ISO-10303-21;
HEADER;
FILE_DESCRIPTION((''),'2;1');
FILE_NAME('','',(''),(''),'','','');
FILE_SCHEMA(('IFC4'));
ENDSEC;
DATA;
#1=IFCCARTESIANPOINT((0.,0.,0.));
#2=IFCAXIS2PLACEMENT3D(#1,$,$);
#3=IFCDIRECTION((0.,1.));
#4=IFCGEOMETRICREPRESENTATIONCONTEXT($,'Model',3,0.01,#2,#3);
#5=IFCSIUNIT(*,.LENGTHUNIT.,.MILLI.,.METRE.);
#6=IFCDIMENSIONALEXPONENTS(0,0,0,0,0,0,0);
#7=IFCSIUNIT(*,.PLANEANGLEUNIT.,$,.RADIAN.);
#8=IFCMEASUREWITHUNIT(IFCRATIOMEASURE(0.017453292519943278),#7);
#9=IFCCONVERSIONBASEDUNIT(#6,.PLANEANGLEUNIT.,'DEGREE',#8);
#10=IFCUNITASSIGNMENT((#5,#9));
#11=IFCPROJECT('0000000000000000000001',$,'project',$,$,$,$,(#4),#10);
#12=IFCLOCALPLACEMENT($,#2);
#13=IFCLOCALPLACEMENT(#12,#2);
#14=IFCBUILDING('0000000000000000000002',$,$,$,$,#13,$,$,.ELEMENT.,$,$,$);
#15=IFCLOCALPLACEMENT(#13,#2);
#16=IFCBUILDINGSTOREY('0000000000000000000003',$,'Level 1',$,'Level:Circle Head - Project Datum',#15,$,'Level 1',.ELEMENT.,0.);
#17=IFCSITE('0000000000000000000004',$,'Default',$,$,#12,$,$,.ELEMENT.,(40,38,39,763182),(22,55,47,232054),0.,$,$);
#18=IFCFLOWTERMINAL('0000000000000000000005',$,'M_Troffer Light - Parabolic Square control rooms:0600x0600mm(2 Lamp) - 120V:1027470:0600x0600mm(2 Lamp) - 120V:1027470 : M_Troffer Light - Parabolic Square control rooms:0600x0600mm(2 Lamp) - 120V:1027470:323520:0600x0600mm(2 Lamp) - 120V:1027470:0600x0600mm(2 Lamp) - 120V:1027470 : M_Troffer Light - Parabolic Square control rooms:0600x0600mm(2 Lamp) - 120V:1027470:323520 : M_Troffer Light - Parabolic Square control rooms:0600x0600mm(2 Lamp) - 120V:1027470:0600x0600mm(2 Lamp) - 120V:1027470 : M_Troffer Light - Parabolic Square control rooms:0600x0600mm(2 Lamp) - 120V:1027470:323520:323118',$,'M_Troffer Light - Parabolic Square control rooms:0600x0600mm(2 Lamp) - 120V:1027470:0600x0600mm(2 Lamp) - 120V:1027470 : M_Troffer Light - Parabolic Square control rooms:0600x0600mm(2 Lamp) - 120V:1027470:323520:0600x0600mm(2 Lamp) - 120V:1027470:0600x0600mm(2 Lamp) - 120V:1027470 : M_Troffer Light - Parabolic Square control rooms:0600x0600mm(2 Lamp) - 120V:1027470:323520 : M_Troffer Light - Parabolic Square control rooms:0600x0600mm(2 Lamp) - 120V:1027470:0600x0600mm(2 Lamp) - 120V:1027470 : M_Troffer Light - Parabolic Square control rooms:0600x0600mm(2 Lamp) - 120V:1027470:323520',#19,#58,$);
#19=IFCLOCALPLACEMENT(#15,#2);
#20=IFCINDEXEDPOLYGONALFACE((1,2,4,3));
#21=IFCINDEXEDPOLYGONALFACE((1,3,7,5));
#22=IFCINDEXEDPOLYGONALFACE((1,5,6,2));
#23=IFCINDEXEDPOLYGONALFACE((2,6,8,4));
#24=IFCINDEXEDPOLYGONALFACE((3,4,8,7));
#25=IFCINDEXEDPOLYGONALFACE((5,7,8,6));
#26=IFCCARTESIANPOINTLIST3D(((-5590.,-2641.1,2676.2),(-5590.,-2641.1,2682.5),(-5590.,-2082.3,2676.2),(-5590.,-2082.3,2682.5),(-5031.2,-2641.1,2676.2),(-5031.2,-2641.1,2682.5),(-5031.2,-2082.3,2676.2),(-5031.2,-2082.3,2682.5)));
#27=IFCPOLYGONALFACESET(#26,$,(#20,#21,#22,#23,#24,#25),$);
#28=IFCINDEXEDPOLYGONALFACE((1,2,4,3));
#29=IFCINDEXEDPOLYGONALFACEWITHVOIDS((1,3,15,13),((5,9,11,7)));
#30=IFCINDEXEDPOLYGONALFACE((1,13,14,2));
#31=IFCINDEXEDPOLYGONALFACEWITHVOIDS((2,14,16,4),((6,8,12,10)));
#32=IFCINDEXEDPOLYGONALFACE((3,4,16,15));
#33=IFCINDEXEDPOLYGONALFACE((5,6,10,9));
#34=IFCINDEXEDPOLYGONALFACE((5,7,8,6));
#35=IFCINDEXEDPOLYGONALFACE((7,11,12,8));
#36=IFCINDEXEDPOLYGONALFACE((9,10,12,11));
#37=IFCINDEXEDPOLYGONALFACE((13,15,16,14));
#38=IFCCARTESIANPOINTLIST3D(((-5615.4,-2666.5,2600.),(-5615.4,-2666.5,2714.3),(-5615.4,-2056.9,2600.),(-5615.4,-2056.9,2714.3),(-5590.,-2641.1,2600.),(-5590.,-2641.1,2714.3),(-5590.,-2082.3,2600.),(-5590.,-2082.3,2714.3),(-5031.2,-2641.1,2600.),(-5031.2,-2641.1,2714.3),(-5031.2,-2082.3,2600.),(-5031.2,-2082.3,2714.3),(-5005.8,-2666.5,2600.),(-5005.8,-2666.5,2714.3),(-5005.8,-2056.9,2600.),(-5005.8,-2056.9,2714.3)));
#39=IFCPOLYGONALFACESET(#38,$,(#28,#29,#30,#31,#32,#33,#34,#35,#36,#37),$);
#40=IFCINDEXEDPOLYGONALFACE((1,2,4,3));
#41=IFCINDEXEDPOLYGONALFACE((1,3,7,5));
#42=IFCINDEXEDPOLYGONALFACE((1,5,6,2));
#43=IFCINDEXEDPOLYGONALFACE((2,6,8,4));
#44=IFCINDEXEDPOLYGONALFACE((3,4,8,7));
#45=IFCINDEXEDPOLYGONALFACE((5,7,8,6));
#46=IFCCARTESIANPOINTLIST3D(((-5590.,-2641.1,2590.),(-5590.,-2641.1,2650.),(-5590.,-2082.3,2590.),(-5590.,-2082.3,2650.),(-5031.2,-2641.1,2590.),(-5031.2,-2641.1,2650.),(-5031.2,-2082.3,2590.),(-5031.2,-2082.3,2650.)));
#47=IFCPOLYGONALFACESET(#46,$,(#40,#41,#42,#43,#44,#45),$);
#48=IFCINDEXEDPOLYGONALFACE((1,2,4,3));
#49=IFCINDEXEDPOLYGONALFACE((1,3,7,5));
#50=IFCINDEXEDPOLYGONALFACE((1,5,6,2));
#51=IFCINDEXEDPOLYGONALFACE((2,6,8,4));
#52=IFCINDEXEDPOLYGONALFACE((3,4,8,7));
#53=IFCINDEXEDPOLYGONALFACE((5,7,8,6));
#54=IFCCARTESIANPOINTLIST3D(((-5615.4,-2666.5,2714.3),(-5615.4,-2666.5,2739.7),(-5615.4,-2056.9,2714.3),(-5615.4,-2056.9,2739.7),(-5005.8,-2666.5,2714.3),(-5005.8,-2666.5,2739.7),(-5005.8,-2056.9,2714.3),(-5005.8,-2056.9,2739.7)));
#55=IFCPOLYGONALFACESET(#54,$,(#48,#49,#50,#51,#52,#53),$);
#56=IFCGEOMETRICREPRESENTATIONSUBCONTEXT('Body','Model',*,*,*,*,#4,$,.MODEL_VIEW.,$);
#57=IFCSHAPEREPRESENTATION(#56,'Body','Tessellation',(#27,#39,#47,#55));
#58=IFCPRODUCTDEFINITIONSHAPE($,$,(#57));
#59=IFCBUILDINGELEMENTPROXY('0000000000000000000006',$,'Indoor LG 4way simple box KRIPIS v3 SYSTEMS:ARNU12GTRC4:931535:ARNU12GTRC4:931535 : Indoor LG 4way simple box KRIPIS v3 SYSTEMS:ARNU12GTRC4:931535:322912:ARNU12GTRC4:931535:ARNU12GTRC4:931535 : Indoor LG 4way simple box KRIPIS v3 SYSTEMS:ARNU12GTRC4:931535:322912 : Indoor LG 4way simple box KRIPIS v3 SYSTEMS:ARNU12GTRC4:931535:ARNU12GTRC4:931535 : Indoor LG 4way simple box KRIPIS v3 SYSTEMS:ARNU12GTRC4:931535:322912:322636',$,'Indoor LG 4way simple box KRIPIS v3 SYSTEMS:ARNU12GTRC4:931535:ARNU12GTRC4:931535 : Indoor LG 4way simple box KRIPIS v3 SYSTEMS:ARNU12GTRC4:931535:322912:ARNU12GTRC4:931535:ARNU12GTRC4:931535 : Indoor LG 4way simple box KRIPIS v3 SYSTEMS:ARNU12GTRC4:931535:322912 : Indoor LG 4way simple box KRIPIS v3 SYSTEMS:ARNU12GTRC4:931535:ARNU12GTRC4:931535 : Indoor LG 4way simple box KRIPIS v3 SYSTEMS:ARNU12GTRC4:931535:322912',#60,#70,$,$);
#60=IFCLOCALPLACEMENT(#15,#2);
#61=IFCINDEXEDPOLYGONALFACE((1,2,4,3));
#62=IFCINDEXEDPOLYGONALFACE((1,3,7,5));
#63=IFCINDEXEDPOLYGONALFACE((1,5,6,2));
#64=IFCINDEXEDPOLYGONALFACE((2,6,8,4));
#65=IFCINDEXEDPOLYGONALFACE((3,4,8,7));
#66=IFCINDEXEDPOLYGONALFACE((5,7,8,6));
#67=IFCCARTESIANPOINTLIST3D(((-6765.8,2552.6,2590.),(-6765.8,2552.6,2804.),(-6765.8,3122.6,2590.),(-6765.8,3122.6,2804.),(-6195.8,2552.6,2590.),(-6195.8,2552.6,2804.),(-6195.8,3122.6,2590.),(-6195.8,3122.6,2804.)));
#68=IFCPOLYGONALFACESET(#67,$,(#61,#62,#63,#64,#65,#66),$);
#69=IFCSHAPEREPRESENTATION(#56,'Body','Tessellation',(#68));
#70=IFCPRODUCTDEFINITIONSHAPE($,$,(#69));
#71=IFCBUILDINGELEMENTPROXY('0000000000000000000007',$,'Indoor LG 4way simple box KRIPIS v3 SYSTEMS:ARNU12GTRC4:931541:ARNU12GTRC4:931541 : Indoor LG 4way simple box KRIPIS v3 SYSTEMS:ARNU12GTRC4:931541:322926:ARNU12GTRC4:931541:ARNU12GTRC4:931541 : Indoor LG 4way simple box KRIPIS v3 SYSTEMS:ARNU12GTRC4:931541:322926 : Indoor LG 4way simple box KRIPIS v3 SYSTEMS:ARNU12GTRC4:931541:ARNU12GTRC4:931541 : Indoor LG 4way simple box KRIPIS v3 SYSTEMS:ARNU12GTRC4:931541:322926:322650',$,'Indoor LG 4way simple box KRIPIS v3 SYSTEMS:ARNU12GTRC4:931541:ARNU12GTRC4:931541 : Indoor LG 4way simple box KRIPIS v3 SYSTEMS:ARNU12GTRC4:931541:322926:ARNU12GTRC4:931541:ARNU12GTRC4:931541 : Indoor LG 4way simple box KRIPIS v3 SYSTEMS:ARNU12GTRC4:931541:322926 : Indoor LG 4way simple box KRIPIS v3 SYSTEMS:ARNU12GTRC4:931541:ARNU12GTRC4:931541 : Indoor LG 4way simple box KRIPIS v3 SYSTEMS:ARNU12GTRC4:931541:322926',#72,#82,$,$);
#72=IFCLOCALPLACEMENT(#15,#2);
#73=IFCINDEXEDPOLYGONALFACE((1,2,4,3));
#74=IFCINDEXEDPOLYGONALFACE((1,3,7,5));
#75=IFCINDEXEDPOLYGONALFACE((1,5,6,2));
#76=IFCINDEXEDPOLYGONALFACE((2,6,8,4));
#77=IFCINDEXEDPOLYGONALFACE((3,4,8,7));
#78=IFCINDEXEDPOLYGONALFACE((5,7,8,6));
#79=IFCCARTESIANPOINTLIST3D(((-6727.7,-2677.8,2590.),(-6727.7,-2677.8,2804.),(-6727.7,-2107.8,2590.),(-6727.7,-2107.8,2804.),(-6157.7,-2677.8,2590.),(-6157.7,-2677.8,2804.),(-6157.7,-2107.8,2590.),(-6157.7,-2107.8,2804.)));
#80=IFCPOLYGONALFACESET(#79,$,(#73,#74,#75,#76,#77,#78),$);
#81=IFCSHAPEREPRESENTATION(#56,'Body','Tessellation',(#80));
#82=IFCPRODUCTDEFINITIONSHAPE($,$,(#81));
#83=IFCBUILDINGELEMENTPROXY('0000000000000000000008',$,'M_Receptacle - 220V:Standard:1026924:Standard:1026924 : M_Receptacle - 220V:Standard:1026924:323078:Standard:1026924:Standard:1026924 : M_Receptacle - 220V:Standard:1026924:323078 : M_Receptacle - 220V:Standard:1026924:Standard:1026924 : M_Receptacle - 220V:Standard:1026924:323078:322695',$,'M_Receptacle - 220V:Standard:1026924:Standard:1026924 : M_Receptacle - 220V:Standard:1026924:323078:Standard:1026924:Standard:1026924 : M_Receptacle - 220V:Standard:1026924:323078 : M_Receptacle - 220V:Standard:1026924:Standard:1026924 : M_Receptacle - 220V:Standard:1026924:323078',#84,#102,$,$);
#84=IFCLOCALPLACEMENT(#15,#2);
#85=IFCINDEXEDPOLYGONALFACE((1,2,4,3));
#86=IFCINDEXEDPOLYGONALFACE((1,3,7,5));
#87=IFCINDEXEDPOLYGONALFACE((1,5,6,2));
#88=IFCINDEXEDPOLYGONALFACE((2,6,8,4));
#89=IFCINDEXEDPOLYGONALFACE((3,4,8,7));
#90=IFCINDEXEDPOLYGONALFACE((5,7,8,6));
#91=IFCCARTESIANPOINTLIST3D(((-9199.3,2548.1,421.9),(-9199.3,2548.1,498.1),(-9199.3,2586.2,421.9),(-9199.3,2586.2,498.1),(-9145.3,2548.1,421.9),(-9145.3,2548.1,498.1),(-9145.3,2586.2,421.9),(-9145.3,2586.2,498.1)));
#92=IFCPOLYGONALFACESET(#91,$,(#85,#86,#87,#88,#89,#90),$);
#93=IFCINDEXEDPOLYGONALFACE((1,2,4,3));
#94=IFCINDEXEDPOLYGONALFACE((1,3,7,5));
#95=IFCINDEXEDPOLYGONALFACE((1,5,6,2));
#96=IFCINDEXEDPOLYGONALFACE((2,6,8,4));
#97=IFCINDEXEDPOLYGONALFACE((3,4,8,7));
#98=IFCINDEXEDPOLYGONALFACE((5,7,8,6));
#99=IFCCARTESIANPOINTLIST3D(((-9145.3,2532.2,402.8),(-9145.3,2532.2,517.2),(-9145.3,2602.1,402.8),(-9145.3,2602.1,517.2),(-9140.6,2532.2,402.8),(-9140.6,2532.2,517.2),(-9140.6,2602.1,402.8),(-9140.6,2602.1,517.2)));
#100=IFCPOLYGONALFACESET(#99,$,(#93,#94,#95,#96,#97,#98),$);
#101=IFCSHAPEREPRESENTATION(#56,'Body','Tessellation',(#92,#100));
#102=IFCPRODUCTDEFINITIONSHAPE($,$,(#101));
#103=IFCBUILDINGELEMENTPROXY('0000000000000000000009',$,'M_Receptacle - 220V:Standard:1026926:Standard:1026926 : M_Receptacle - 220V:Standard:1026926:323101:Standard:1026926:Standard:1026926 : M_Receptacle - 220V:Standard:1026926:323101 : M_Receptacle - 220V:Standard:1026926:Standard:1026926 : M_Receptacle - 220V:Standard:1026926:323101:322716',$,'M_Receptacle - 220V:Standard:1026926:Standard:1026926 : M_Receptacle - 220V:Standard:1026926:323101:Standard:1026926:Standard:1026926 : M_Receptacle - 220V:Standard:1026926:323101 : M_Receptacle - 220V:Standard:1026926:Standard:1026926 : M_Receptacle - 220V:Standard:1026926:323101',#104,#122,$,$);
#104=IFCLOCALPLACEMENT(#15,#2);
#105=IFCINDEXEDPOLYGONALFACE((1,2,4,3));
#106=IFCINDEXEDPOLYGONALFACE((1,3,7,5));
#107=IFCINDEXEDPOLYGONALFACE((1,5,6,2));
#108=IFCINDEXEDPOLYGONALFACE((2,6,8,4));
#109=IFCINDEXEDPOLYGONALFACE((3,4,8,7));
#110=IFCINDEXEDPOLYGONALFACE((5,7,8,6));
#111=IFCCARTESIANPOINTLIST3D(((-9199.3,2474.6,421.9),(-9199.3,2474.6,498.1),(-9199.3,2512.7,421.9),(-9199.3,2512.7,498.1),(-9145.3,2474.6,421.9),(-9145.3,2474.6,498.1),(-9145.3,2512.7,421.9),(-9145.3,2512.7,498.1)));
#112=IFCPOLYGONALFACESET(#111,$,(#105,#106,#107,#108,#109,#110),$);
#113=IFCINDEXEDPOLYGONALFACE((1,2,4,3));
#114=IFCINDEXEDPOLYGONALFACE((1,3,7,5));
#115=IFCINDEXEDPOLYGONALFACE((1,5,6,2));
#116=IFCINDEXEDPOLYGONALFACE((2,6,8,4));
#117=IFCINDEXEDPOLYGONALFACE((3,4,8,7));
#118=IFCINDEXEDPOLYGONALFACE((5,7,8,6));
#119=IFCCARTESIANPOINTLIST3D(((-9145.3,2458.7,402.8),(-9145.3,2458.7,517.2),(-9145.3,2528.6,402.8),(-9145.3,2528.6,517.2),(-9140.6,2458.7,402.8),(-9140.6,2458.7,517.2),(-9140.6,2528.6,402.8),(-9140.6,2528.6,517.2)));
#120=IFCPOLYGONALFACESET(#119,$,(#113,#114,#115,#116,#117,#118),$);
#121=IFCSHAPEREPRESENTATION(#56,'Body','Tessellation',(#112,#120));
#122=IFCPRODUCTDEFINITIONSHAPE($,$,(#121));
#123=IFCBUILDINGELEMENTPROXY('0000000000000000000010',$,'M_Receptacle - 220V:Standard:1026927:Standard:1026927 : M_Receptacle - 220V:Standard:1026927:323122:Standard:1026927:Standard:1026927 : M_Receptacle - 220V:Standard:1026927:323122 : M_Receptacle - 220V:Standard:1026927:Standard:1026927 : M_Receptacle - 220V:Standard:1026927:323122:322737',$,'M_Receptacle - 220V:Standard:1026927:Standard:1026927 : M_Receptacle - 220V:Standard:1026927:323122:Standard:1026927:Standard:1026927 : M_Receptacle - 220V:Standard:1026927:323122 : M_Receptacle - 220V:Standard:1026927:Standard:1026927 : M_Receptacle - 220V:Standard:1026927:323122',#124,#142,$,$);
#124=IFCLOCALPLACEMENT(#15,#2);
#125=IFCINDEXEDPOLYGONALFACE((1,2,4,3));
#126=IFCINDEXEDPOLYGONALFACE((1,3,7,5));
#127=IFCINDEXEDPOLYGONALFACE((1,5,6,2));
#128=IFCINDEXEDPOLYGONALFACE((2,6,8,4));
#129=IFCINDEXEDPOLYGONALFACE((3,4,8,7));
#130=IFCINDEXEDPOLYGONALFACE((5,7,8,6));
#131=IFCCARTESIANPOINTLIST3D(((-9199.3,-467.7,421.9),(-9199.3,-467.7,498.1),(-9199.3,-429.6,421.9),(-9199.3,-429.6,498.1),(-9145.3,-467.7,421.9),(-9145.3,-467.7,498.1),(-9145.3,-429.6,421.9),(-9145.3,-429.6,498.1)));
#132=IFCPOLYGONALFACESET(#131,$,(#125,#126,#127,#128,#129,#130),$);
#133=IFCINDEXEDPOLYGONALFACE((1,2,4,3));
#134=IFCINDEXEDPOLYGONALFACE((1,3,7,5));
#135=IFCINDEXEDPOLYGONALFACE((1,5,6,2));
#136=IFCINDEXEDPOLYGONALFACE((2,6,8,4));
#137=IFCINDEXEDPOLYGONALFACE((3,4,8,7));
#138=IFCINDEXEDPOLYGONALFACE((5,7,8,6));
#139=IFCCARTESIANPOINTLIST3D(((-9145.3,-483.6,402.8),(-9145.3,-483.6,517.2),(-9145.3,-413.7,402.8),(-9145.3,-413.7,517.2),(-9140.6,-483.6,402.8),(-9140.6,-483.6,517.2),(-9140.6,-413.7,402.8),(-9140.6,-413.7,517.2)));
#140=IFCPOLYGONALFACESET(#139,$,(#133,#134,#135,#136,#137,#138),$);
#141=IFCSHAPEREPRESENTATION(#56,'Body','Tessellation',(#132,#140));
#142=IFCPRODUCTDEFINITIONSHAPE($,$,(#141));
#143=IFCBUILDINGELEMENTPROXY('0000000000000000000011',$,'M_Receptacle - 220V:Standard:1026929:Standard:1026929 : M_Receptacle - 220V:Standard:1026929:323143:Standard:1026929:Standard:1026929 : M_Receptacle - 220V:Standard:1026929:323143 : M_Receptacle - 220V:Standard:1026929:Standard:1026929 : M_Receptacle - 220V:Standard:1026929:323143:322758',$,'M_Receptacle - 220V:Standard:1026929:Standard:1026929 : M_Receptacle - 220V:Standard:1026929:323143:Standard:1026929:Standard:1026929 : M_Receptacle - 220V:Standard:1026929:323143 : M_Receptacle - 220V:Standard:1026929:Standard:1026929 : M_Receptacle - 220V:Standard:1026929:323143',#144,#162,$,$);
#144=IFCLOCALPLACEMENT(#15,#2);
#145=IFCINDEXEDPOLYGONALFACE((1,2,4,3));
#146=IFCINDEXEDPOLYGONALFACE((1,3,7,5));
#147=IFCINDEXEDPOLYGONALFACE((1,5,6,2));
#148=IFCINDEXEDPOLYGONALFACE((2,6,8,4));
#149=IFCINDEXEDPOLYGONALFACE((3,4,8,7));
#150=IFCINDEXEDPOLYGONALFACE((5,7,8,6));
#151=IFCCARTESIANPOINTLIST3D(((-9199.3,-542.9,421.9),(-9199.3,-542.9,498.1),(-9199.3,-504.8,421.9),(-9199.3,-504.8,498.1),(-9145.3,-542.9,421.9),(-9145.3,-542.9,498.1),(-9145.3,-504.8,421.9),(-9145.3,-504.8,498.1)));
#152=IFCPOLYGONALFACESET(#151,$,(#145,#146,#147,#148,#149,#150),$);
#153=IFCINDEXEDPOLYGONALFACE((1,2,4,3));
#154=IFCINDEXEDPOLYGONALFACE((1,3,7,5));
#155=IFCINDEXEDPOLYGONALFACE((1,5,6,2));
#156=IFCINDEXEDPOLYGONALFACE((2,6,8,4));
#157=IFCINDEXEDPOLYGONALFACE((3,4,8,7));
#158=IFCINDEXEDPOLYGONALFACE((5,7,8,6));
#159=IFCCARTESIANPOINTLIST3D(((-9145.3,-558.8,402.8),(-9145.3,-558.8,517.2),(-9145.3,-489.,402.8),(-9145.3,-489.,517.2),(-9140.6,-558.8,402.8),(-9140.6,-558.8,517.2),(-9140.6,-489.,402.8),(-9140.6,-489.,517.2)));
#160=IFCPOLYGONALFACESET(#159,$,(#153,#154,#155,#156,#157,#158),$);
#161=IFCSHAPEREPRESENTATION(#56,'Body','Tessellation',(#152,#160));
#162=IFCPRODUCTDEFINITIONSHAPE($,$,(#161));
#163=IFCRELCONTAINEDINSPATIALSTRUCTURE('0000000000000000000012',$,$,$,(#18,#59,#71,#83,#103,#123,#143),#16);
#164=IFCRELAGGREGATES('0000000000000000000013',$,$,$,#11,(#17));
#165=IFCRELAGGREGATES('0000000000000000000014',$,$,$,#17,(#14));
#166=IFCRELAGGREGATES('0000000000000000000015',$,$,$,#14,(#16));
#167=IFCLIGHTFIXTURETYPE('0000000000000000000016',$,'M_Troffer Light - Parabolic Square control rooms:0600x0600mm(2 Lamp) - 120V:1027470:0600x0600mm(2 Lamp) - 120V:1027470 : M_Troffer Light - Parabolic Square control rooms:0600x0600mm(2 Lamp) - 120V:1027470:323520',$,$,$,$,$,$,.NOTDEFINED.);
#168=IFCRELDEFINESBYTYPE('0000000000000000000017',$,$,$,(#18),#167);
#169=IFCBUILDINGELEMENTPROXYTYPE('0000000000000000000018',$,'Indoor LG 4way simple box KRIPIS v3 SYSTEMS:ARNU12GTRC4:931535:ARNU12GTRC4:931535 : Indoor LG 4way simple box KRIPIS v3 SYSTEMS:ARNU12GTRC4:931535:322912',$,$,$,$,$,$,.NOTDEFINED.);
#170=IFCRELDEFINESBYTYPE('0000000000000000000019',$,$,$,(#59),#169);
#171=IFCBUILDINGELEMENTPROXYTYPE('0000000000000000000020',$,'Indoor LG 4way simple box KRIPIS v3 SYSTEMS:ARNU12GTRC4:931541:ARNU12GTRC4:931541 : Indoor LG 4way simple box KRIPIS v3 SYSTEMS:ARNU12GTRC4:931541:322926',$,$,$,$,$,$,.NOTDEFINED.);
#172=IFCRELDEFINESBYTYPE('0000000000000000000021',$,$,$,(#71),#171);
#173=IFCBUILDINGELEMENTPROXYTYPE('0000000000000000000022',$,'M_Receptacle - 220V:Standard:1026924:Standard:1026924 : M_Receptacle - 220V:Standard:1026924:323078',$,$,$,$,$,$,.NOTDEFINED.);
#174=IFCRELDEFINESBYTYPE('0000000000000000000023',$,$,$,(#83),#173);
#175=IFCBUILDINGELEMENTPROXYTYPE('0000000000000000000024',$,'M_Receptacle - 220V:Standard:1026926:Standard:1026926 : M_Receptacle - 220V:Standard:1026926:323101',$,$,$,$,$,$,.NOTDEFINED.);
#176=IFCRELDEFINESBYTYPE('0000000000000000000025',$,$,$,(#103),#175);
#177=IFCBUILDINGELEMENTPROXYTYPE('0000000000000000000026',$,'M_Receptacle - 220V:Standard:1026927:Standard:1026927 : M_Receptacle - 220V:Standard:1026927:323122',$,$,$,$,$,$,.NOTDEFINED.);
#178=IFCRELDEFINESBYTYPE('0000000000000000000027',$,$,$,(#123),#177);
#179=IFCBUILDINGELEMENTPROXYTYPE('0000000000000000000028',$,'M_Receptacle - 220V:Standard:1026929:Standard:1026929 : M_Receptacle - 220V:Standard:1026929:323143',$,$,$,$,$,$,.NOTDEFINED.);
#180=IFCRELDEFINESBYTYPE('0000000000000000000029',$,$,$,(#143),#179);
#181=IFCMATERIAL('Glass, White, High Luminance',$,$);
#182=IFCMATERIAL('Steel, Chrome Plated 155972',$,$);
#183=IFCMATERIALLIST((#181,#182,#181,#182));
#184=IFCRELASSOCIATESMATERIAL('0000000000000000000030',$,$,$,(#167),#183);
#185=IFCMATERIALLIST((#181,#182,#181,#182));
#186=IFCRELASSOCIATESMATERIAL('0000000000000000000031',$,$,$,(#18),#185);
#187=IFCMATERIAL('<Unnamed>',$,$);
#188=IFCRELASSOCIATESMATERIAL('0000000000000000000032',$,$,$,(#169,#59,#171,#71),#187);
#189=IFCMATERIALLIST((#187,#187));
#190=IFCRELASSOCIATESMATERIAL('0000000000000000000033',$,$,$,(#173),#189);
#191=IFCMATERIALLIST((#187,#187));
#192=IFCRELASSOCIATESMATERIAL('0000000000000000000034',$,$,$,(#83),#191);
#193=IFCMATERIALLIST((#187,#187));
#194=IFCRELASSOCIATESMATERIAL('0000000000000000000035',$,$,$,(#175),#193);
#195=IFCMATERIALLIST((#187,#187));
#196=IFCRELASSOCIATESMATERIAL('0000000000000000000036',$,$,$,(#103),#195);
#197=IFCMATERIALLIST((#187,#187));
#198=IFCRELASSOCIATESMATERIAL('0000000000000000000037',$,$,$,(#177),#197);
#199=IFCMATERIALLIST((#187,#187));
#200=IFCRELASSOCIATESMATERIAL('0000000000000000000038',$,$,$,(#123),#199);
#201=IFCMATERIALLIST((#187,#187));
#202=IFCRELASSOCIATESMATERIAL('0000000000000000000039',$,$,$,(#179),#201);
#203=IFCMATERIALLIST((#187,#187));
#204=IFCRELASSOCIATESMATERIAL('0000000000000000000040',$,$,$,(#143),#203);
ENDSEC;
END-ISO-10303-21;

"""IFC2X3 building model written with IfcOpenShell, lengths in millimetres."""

from ifc_helpers import new_model, entity, si_unit, converted_unit, direction, frame, frame_2d, origin, origin_2d_with_axis, place, context, subcontext, project, spatial, polyline, rectangle, outline, extrude, source, transform, mapped, material, material_list, type_object, type_shapes, element, save


model = new_model("IFC2X3")

# Units and contexts
model_context = context("Model", 3, precision=0.01, world=origin(), true_north=direction((0.0, 1.0)))
body_context = subcontext(model_context, "Body", "Model", "MODEL_VIEW")
ifc_project = project(units=[si_unit("LENGTHUNIT", "METRE", prefix="MILLI"), converted_unit("PLANEANGLEUNIT", "DEGREE", entity("IfcRatioMeasure", 0.017453292519943278), si_unit("PLANEANGLEUNIT", "RADIAN"), dimensions=[0, 0, 0, 0, 0, 0, 0])], contexts=[model_context])

# Site, building, storey
site_placement = place(None, origin())
site = spatial("IfcSite", under=ifc_project, at=site_placement, Name="Default", CompositionType="ELEMENT", RefLatitude=(40, 38, 39, 763182), RefLongitude=(22, 55, 47, 232054), RefElevation=0.0)
building_placement = place(site_placement, origin())
building = spatial("IfcBuilding", under=site, at=building_placement, CompositionType="ELEMENT")
storey_placement = place(building_placement, origin())
storey = spatial("IfcBuildingStorey", under=building, at=storey_placement, Name="Level 1", ObjectType="Level:Circle Head - Project Datum", LongName="Level 1", CompositionType="ELEMENT", Elevation=0.0)

# Shared definitions
ifc_material_1 = material(Name="<Unnamed>")

# Flow terminal
ifc_material_2 = material(Name="Glass, White, High Luminance")
ifc_material_3 = material(Name="Steel, Chrome Plated 155972")
ifc_material_list_1 = material_list([ifc_material_2, ifc_material_3, ifc_material_2, ifc_material_3])
ifc_material_list_2 = material_list([ifc_material_2, ifc_material_3, ifc_material_2, ifc_material_3])
light_fixture_type_1 = type_object("IfcLightFixtureType", Name="M_Troffer Light - Parabolic Square control rooms:0600x0600mm(2 Lamp) - 120V:1027470:0600x0600mm(2 Lamp) - 120V:1027470 : M_Troffer Light - Parabolic Square control rooms:0600x0600mm(2 Lamp) - 120V:1027470:323520", PredefinedType="NOTDEFINED", material=ifc_material_list_2)
shared_shape_1 = source(origin(), body_context, "Body", "SweptSolid", [
    extrude(rectangle(XDim=558.8, YDim=558.8, at=frame_2d((0.0, 0.0), x_axis=(1.0, 0.0))), frame((-5310.6, -2361.7, 2676.2), z_axis=(0.0, 0.0, 1.0), x_axis=(0.0, 1.0, 0.0)), (0.0, 0.0, 1.0), 6.4),
    extrude(outline(polyline([(-304.8, -304.8), (304.8, -304.8), (304.8, 304.8), (-304.8, 304.8), (-304.8, -304.8)]), holes=[polyline([(279.4, 279.4), (279.4, -279.4), (-279.4, -279.4), (-279.4, 279.4), (279.4, 279.4)])]), frame((-5310.6, -2361.7, 2600.0), z_axis=(0.0, 0.0, 1.0), x_axis=(0.0, -1.0, 0.0)), (0.0, 0.0, 1.0), 114.3),
    extrude(rectangle(XDim=558.8, YDim=558.8, at=frame_2d((0.0, 0.0), x_axis=(1.0, 0.0))), frame((-5310.6, -2361.7, 2590.0), z_axis=(0.0, 0.0, 1.0), x_axis=(0.0, 1.0, 0.0)), (0.0, 0.0, 1.0), 60.0),
    extrude(rectangle(XDim=609.6, YDim=609.6, at=origin_2d_with_axis()), frame((-5310.6, -2361.7, 2714.3), z_axis=(0.0, 0.0, 1.0), x_axis=(0.0, 1.0, 0.0)), (0.0, 0.0, 1.0), 25.4),
])
type_shapes(light_fixture_type_1, [shared_shape_1])
flow_terminal_1_placement = place(storey_placement, origin())
element("IfcFlowTerminal", 1, at=flow_terminal_1_placement, inside=storey, type_object=light_fixture_type_1, material=ifc_material_list_1, Name="M_Troffer Light - Parabolic Square control rooms:0600x0600mm(2 Lamp) - 120V:1027470:0600x0600mm(2 Lamp) - 120V:1027470 : M_Troffer Light - Parabolic Square control rooms:0600x0600mm(2 Lamp) - 120V:1027470:323520:0600x0600mm(2 Lamp) - 120V:1027470:0600x0600mm(2 Lamp) - 120V:1027470 : M_Troffer Light - Parabolic Square control rooms:0600x0600mm(2 Lamp) - 120V:1027470:323520 : M_Troffer Light - Parabolic Square control rooms:0600x0600mm(2 Lamp) - 120V:1027470:0600x0600mm(2 Lamp) - 120V:1027470 : M_Troffer Light - Parabolic Square control rooms:0600x0600mm(2 Lamp) - 120V:1027470:323520:323118", ObjectType="M_Troffer Light - Parabolic Square control rooms:0600x0600mm(2 Lamp) - 120V:1027470:0600x0600mm(2 Lamp) - 120V:1027470 : M_Troffer Light - Parabolic Square control rooms:0600x0600mm(2 Lamp) - 120V:1027470:323520:0600x0600mm(2 Lamp) - 120V:1027470:0600x0600mm(2 Lamp) - 120V:1027470 : M_Troffer Light - Parabolic Square control rooms:0600x0600mm(2 Lamp) - 120V:1027470:323520 : M_Troffer Light - Parabolic Square control rooms:0600x0600mm(2 Lamp) - 120V:1027470:0600x0600mm(2 Lamp) - 120V:1027470 : M_Troffer Light - Parabolic Square control rooms:0600x0600mm(2 Lamp) - 120V:1027470:323520", context=body_context, shape_type="MappedRepresentation", body=[
    mapped(shared_shape_1, transform((0.0, 0.0, 0.0), scale=1.0)),
])

# Building element proxies
building_element_proxy_type_1 = type_object("IfcBuildingElementProxyType", Name="Indoor LG 4way simple box KRIPIS v3 SYSTEMS:ARNU12GTRC4:931535:ARNU12GTRC4:931535 : Indoor LG 4way simple box KRIPIS v3 SYSTEMS:ARNU12GTRC4:931535:322912", PredefinedType="NOTDEFINED", material=ifc_material_1)
shared_shape_2 = source(origin(), body_context, "Body", "SweptSolid", [
    extrude(rectangle(XDim=570.0, YDim=570.0, at=frame_2d((0.0, 0.0), x_axis=(1.0, 0.0))), frame((-6480.8, 2837.6, 2590.0), z_axis=(0.0, 0.0, 1.0), x_axis=(0.0, 1.0, 0.0)), (0.0, 0.0, 1.0), 214.0),
])
type_shapes(building_element_proxy_type_1, [shared_shape_2])
proxy_1_placement = place(storey_placement, origin())
element("IfcBuildingElementProxy", 2, at=proxy_1_placement, inside=storey, type_object=building_element_proxy_type_1, material=ifc_material_1, Name="Indoor LG 4way simple box KRIPIS v3 SYSTEMS:ARNU12GTRC4:931535:ARNU12GTRC4:931535 : Indoor LG 4way simple box KRIPIS v3 SYSTEMS:ARNU12GTRC4:931535:322912:ARNU12GTRC4:931535:ARNU12GTRC4:931535 : Indoor LG 4way simple box KRIPIS v3 SYSTEMS:ARNU12GTRC4:931535:322912 : Indoor LG 4way simple box KRIPIS v3 SYSTEMS:ARNU12GTRC4:931535:ARNU12GTRC4:931535 : Indoor LG 4way simple box KRIPIS v3 SYSTEMS:ARNU12GTRC4:931535:322912:322636", ObjectType="Indoor LG 4way simple box KRIPIS v3 SYSTEMS:ARNU12GTRC4:931535:ARNU12GTRC4:931535 : Indoor LG 4way simple box KRIPIS v3 SYSTEMS:ARNU12GTRC4:931535:322912:ARNU12GTRC4:931535:ARNU12GTRC4:931535 : Indoor LG 4way simple box KRIPIS v3 SYSTEMS:ARNU12GTRC4:931535:322912 : Indoor LG 4way simple box KRIPIS v3 SYSTEMS:ARNU12GTRC4:931535:ARNU12GTRC4:931535 : Indoor LG 4way simple box KRIPIS v3 SYSTEMS:ARNU12GTRC4:931535:322912", context=body_context, shape_type="MappedRepresentation", body=[
    mapped(shared_shape_2, transform((0.0, 0.0, 0.0), scale=1.0)),
])
building_element_proxy_type_2 = type_object("IfcBuildingElementProxyType", Name="Indoor LG 4way simple box KRIPIS v3 SYSTEMS:ARNU12GTRC4:931541:ARNU12GTRC4:931541 : Indoor LG 4way simple box KRIPIS v3 SYSTEMS:ARNU12GTRC4:931541:322926", PredefinedType="NOTDEFINED", material=ifc_material_1)
shared_shape_3 = source(origin(), body_context, "Body", "SweptSolid", [
    extrude(rectangle(XDim=570.0, YDim=570.0, at=frame_2d((0.0, 0.0), x_axis=(1.0, 0.0))), frame((-6442.7, -2392.8, 2590.0), z_axis=(0.0, 0.0, 1.0), x_axis=(0.0, 1.0, 0.0)), (0.0, 0.0, 1.0), 214.0),
])
type_shapes(building_element_proxy_type_2, [shared_shape_3])
proxy_2_placement = place(storey_placement, origin())
element("IfcBuildingElementProxy", 3, at=proxy_2_placement, inside=storey, type_object=building_element_proxy_type_2, material=ifc_material_1, Name="Indoor LG 4way simple box KRIPIS v3 SYSTEMS:ARNU12GTRC4:931541:ARNU12GTRC4:931541 : Indoor LG 4way simple box KRIPIS v3 SYSTEMS:ARNU12GTRC4:931541:322926:ARNU12GTRC4:931541:ARNU12GTRC4:931541 : Indoor LG 4way simple box KRIPIS v3 SYSTEMS:ARNU12GTRC4:931541:322926 : Indoor LG 4way simple box KRIPIS v3 SYSTEMS:ARNU12GTRC4:931541:ARNU12GTRC4:931541 : Indoor LG 4way simple box KRIPIS v3 SYSTEMS:ARNU12GTRC4:931541:322926:322650", ObjectType="Indoor LG 4way simple box KRIPIS v3 SYSTEMS:ARNU12GTRC4:931541:ARNU12GTRC4:931541 : Indoor LG 4way simple box KRIPIS v3 SYSTEMS:ARNU12GTRC4:931541:322926:ARNU12GTRC4:931541:ARNU12GTRC4:931541 : Indoor LG 4way simple box KRIPIS v3 SYSTEMS:ARNU12GTRC4:931541:322926 : Indoor LG 4way simple box KRIPIS v3 SYSTEMS:ARNU12GTRC4:931541:ARNU12GTRC4:931541 : Indoor LG 4way simple box KRIPIS v3 SYSTEMS:ARNU12GTRC4:931541:322926", context=body_context, shape_type="MappedRepresentation", body=[
    mapped(shared_shape_3, transform((0.0, 0.0, 0.0), scale=1.0)),
])
ifc_material_list_3 = material_list([ifc_material_1, ifc_material_1])
ifc_material_list_4 = material_list([ifc_material_1, ifc_material_1])
building_element_proxy_type_3 = type_object("IfcBuildingElementProxyType", Name="M_Receptacle - 220V:Standard:1026924:Standard:1026924 : M_Receptacle - 220V:Standard:1026924:323078", PredefinedType="NOTDEFINED", material=ifc_material_list_4)
shared_shape_4 = source(origin(), body_context, "Body", "SweptSolid", [
    extrude(rectangle(XDim=38.1, YDim=54.0, at=frame_2d((0.0, 0.0), x_axis=(1.0, 0.0))), frame((-9172.3, 2567.2, 421.9), z_axis=(0.0, 0.0, 1.0), x_axis=(0.0, -1.0, 0.0)), (0.0, 0.0, 1.0), 76.2),
    extrude(rectangle(XDim=69.8, YDim=4.8, at=frame_2d((0.0, 0.0), x_axis=(1.0, 0.0))), frame((-9143.0, 2567.2, 402.8), z_axis=(0.0, 0.0, 1.0), x_axis=(0.0, -1.0, 0.0)), (0.0, 0.0, 1.0), 114.3),
])
type_shapes(building_element_proxy_type_3, [shared_shape_4])
proxy_3_placement = place(storey_placement, origin())
element("IfcBuildingElementProxy", 4, at=proxy_3_placement, inside=storey, type_object=building_element_proxy_type_3, material=ifc_material_list_3, Name="M_Receptacle - 220V:Standard:1026924:Standard:1026924 : M_Receptacle - 220V:Standard:1026924:323078:Standard:1026924:Standard:1026924 : M_Receptacle - 220V:Standard:1026924:323078 : M_Receptacle - 220V:Standard:1026924:Standard:1026924 : M_Receptacle - 220V:Standard:1026924:323078:322695", ObjectType="M_Receptacle - 220V:Standard:1026924:Standard:1026924 : M_Receptacle - 220V:Standard:1026924:323078:Standard:1026924:Standard:1026924 : M_Receptacle - 220V:Standard:1026924:323078 : M_Receptacle - 220V:Standard:1026924:Standard:1026924 : M_Receptacle - 220V:Standard:1026924:323078", context=body_context, shape_type="MappedRepresentation", body=[
    mapped(shared_shape_4, transform((0.0, 0.0, 0.0), scale=1.0)),
])
ifc_material_list_5 = material_list([ifc_material_1, ifc_material_1])
ifc_material_list_6 = material_list([ifc_material_1, ifc_material_1])
building_element_proxy_type_4 = type_object("IfcBuildingElementProxyType", Name="M_Receptacle - 220V:Standard:1026926:Standard:1026926 : M_Receptacle - 220V:Standard:1026926:323101", PredefinedType="NOTDEFINED", material=ifc_material_list_6)
shared_shape_5 = source(origin(), body_context, "Body", "SweptSolid", [
    extrude(rectangle(XDim=38.1, YDim=54.0, at=frame_2d((0.0, 0.0), x_axis=(1.0, 0.0))), frame((-9172.3, 2493.7, 421.9), z_axis=(0.0, 0.0, 1.0), x_axis=(0.0, -1.0, 0.0)), (0.0, 0.0, 1.0), 76.2),
    extrude(rectangle(XDim=69.8, YDim=4.8, at=frame_2d((0.0, 0.0), x_axis=(1.0, 0.0))), frame((-9143.0, 2493.7, 402.8), z_axis=(0.0, 0.0, 1.0), x_axis=(0.0, -1.0, 0.0)), (0.0, 0.0, 1.0), 114.3),
])
type_shapes(building_element_proxy_type_4, [shared_shape_5])
proxy_4_placement = place(storey_placement, origin())
element("IfcBuildingElementProxy", 5, at=proxy_4_placement, inside=storey, type_object=building_element_proxy_type_4, material=ifc_material_list_5, Name="M_Receptacle - 220V:Standard:1026926:Standard:1026926 : M_Receptacle - 220V:Standard:1026926:323101:Standard:1026926:Standard:1026926 : M_Receptacle - 220V:Standard:1026926:323101 : M_Receptacle - 220V:Standard:1026926:Standard:1026926 : M_Receptacle - 220V:Standard:1026926:323101:322716", ObjectType="M_Receptacle - 220V:Standard:1026926:Standard:1026926 : M_Receptacle - 220V:Standard:1026926:323101:Standard:1026926:Standard:1026926 : M_Receptacle - 220V:Standard:1026926:323101 : M_Receptacle - 220V:Standard:1026926:Standard:1026926 : M_Receptacle - 220V:Standard:1026926:323101", context=body_context, shape_type="MappedRepresentation", body=[
    mapped(shared_shape_5, transform((0.0, 0.0, 0.0), scale=1.0)),
])
ifc_material_list_7 = material_list([ifc_material_1, ifc_material_1])
ifc_material_list_8 = material_list([ifc_material_1, ifc_material_1])
building_element_proxy_type_5 = type_object("IfcBuildingElementProxyType", Name="M_Receptacle - 220V:Standard:1026927:Standard:1026927 : M_Receptacle - 220V:Standard:1026927:323122", PredefinedType="NOTDEFINED", material=ifc_material_list_8)
shared_shape_6 = source(origin(), body_context, "Body", "SweptSolid", [
    extrude(rectangle(XDim=38.1, YDim=54.0, at=frame_2d((0.0, 0.0), x_axis=(1.0, 0.0))), frame((-9172.3, -448.7, 421.9), z_axis=(0.0, 0.0, 1.0), x_axis=(0.0, -1.0, 0.0)), (0.0, 0.0, 1.0), 76.2),
    extrude(rectangle(XDim=69.8, YDim=4.8, at=frame_2d((0.0, 0.0), x_axis=(1.0, 0.0))), frame((-9143.0, -448.7, 402.8), z_axis=(0.0, 0.0, 1.0), x_axis=(0.0, -1.0, 0.0)), (0.0, 0.0, 1.0), 114.3),
])
type_shapes(building_element_proxy_type_5, [shared_shape_6])
proxy_5_placement = place(storey_placement, origin())
element("IfcBuildingElementProxy", 6, at=proxy_5_placement, inside=storey, type_object=building_element_proxy_type_5, material=ifc_material_list_7, Name="M_Receptacle - 220V:Standard:1026927:Standard:1026927 : M_Receptacle - 220V:Standard:1026927:323122:Standard:1026927:Standard:1026927 : M_Receptacle - 220V:Standard:1026927:323122 : M_Receptacle - 220V:Standard:1026927:Standard:1026927 : M_Receptacle - 220V:Standard:1026927:323122:322737", ObjectType="M_Receptacle - 220V:Standard:1026927:Standard:1026927 : M_Receptacle - 220V:Standard:1026927:323122:Standard:1026927:Standard:1026927 : M_Receptacle - 220V:Standard:1026927:323122 : M_Receptacle - 220V:Standard:1026927:Standard:1026927 : M_Receptacle - 220V:Standard:1026927:323122", context=body_context, shape_type="MappedRepresentation", body=[
    mapped(shared_shape_6, transform((0.0, 0.0, 0.0), scale=1.0)),
])
ifc_material_list_9 = material_list([ifc_material_1, ifc_material_1])
ifc_material_list_10 = material_list([ifc_material_1, ifc_material_1])
building_element_proxy_type_6 = type_object("IfcBuildingElementProxyType", Name="M_Receptacle - 220V:Standard:1026929:Standard:1026929 : M_Receptacle - 220V:Standard:1026929:323143", PredefinedType="NOTDEFINED", material=ifc_material_list_10)
shared_shape_7 = source(origin(), body_context, "Body", "SweptSolid", [
    extrude(rectangle(XDim=38.1, YDim=54.0, at=origin_2d_with_axis()), frame((-9172.3, -523.9, 421.9), z_axis=(0.0, 0.0, 1.0), x_axis=(0.0, -1.0, 0.0)), (0.0, 0.0, 1.0), 76.2),
    extrude(rectangle(XDim=69.8, YDim=4.8, at=frame_2d((0.0, 0.0), x_axis=(1.0, 0.0))), frame((-9143.0, -523.9, 402.8), z_axis=(0.0, 0.0, 1.0), x_axis=(0.0, -1.0, 0.0)), (0.0, 0.0, 1.0), 114.3),
])
type_shapes(building_element_proxy_type_6, [shared_shape_7])
proxy_6_placement = place(storey_placement, origin())
element("IfcBuildingElementProxy", 7, at=proxy_6_placement, inside=storey, type_object=building_element_proxy_type_6, material=ifc_material_list_9, Name="M_Receptacle - 220V:Standard:1026929:Standard:1026929 : M_Receptacle - 220V:Standard:1026929:323143:Standard:1026929:Standard:1026929 : M_Receptacle - 220V:Standard:1026929:323143 : M_Receptacle - 220V:Standard:1026929:Standard:1026929 : M_Receptacle - 220V:Standard:1026929:323143:322758", ObjectType="M_Receptacle - 220V:Standard:1026929:Standard:1026929 : M_Receptacle - 220V:Standard:1026929:323143:Standard:1026929:Standard:1026929 : M_Receptacle - 220V:Standard:1026929:323143 : M_Receptacle - 220V:Standard:1026929:Standard:1026929 : M_Receptacle - 220V:Standard:1026929:323143", context=body_context, shape_type="MappedRepresentation", body=[
    mapped(shared_shape_7, transform((0.0, 0.0, 0.0), scale=1.0)),
])

save(model, "model.ifc")
